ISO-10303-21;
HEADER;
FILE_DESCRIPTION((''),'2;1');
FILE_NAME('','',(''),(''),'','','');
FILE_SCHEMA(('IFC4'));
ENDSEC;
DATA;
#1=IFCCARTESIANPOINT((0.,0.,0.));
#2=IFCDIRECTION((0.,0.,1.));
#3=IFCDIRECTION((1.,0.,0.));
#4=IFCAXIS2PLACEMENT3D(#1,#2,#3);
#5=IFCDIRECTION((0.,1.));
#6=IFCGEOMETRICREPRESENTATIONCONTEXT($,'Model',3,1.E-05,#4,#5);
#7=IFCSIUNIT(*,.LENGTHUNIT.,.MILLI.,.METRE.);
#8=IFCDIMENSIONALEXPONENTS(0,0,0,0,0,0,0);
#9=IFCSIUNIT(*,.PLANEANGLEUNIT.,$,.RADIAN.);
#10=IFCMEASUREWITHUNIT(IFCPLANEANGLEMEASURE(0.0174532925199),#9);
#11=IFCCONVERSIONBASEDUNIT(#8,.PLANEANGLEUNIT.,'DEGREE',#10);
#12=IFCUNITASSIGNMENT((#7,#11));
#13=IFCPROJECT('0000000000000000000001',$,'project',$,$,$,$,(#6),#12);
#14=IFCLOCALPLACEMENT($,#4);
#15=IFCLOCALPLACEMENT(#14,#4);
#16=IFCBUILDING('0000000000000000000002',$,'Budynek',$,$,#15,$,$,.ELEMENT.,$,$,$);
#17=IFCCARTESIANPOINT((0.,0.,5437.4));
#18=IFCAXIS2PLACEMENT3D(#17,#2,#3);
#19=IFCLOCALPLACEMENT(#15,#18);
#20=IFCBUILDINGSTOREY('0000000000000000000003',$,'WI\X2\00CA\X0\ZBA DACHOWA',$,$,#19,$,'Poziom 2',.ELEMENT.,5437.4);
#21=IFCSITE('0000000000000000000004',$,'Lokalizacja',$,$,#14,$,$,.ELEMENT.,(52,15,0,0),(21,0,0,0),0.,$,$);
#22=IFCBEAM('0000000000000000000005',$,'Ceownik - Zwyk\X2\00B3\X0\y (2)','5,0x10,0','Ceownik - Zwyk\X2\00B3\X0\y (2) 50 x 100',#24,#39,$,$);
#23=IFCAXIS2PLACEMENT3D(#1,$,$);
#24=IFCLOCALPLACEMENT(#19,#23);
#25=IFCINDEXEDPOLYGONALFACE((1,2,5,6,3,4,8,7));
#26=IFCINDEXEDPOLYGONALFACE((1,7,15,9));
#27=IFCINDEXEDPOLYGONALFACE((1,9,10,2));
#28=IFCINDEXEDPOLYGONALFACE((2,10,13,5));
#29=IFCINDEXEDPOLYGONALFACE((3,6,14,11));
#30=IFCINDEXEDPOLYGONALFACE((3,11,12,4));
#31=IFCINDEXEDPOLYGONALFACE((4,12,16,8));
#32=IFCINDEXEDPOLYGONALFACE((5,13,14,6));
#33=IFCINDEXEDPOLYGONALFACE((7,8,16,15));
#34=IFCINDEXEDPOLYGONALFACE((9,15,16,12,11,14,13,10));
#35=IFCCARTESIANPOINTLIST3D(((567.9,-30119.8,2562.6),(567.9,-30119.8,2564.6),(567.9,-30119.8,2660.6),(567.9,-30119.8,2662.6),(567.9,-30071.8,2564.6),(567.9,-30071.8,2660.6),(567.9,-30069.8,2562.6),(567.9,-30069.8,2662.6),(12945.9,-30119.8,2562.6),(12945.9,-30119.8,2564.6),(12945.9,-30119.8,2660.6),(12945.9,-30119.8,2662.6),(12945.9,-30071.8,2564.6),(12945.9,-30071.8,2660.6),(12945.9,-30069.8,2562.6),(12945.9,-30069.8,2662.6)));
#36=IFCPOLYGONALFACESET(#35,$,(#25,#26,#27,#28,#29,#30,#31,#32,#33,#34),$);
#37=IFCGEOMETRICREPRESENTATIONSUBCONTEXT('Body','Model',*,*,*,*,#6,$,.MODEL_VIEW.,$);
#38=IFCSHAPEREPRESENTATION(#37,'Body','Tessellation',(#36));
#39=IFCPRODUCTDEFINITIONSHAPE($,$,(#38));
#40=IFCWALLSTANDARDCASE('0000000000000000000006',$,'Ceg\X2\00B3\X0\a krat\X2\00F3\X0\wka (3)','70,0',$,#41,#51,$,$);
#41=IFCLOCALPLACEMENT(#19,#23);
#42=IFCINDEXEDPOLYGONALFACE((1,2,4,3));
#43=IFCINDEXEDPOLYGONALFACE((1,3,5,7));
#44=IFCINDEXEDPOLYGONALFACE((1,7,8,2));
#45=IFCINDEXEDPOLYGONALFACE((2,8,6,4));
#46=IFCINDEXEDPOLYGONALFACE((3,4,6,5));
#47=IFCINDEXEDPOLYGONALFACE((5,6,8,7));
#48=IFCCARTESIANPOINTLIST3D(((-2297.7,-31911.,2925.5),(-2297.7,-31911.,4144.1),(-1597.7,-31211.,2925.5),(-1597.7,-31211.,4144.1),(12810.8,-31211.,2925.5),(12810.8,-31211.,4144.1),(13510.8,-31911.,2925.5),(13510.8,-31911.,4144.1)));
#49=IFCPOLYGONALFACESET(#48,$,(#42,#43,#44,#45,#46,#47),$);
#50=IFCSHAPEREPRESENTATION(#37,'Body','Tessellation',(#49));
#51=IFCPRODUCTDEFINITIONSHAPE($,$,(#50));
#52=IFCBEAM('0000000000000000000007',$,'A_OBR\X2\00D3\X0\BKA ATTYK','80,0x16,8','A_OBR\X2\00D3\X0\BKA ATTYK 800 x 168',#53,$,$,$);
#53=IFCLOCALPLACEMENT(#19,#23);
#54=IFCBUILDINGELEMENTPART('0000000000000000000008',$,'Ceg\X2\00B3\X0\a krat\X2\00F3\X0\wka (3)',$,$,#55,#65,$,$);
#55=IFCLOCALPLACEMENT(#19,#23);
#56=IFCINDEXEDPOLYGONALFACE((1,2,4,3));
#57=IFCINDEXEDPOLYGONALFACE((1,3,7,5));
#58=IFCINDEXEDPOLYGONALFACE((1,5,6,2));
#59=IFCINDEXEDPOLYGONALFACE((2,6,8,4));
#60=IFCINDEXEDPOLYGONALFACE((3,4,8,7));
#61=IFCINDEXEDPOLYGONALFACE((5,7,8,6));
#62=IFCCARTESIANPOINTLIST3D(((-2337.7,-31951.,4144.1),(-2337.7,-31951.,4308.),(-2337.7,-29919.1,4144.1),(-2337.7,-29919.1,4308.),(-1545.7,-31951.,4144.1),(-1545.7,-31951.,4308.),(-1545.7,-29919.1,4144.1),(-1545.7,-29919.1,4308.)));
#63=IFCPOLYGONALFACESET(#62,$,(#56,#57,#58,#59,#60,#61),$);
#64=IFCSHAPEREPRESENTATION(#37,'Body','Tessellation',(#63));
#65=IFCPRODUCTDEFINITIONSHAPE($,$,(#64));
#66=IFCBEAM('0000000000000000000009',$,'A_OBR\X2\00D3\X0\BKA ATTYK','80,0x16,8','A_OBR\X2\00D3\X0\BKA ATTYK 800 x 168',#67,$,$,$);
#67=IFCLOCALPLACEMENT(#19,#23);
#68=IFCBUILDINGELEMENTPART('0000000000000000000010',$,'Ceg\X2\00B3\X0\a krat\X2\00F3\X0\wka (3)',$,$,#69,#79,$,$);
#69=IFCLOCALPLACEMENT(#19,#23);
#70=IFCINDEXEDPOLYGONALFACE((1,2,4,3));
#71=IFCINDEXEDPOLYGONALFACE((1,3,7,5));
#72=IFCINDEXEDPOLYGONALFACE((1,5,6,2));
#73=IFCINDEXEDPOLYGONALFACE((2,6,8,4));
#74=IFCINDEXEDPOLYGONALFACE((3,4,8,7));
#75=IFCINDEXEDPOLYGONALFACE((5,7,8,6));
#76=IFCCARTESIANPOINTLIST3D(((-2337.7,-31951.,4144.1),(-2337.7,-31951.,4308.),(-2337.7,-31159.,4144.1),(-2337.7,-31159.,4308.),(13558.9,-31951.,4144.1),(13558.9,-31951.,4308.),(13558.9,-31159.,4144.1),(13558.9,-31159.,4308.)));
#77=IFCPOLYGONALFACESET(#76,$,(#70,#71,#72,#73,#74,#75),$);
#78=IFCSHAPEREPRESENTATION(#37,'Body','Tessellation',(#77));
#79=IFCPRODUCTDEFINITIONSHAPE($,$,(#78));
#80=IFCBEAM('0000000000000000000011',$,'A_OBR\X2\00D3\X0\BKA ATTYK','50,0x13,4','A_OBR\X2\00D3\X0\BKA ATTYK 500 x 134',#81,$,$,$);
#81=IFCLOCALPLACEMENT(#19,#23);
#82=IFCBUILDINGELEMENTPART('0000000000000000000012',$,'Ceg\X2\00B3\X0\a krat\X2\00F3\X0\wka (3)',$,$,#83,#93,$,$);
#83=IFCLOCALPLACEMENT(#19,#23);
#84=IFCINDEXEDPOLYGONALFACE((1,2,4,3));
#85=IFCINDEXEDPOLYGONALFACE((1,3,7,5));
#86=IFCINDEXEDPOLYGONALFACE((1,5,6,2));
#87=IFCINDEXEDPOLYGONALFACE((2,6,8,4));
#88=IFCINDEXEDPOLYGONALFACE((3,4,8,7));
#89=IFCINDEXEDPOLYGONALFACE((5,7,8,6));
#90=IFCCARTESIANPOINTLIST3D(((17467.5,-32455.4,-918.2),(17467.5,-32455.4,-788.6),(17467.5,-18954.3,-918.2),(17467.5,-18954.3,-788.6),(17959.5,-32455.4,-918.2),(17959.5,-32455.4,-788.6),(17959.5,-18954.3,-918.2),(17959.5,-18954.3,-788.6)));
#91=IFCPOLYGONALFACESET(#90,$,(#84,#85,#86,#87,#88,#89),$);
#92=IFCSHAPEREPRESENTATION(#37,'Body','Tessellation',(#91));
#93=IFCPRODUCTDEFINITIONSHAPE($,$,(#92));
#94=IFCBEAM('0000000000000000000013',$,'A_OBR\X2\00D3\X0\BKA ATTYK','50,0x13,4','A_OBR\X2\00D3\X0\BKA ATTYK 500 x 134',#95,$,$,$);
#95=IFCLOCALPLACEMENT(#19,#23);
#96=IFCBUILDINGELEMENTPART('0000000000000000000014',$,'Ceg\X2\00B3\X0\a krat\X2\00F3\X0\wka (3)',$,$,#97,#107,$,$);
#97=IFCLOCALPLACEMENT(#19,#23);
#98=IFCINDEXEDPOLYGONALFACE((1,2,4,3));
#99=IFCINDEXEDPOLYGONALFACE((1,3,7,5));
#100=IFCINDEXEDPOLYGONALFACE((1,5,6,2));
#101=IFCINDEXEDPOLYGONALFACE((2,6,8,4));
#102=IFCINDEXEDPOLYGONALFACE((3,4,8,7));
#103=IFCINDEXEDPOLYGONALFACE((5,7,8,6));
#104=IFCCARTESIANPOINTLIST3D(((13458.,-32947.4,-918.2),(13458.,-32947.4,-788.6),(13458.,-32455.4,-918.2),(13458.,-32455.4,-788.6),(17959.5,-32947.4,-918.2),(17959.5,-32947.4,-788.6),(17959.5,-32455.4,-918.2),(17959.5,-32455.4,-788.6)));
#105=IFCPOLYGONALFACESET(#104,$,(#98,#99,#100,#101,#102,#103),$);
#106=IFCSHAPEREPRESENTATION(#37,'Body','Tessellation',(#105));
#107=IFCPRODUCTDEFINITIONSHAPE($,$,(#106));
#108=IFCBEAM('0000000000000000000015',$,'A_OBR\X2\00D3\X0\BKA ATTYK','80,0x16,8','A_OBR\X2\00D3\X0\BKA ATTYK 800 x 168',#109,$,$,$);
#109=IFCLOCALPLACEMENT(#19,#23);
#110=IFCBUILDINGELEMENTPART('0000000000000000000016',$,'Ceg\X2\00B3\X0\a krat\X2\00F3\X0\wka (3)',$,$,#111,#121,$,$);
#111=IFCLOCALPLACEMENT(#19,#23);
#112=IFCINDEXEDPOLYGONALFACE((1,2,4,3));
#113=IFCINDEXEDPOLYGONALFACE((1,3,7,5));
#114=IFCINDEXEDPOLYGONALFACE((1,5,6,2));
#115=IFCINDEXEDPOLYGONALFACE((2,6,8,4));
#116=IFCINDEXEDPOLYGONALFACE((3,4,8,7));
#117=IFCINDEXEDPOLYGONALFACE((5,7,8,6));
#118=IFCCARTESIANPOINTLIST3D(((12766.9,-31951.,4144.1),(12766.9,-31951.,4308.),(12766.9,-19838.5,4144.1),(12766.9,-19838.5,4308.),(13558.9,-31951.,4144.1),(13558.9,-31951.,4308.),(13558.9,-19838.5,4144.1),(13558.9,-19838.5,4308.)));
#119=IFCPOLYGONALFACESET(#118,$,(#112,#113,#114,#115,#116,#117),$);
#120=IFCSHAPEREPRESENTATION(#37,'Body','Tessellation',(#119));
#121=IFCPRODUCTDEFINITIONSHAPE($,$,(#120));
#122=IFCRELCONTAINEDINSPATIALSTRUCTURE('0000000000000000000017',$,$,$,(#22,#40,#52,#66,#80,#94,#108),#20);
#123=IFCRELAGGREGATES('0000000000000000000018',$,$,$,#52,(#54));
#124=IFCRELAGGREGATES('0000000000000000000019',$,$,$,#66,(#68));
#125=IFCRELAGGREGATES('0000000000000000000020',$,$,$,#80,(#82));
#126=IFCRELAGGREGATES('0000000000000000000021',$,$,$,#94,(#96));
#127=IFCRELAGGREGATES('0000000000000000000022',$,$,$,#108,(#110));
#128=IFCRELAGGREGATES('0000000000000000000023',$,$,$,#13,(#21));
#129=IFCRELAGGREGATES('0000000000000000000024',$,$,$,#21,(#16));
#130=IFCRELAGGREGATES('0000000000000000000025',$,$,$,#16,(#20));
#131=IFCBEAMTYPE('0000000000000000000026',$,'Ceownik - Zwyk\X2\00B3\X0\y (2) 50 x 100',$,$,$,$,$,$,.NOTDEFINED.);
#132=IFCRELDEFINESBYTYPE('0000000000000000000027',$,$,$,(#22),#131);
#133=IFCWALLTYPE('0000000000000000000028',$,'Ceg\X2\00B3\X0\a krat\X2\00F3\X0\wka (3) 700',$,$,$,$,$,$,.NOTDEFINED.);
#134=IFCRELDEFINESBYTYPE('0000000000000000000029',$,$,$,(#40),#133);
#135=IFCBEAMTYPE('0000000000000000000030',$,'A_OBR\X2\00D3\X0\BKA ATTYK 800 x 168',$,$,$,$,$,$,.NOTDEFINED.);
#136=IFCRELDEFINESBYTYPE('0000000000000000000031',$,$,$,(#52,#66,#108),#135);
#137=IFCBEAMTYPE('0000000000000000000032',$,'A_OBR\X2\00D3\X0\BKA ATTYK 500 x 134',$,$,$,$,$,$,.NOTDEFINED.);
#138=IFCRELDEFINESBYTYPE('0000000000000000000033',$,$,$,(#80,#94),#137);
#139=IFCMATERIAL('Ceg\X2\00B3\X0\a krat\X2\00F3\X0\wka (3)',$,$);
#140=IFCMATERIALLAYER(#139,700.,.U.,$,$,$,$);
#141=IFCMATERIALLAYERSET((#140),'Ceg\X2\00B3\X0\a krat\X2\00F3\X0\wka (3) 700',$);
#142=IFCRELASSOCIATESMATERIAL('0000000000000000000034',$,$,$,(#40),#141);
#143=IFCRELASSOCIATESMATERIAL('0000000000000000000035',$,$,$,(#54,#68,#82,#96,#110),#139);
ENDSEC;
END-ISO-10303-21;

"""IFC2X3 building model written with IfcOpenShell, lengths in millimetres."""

from ifc_helpers import new_model, entity, si_unit, converted_unit, direction, frame, origin_with_axes, place, context, subcontext, project, spatial, polyline, outline, extrude, material, layer, layer_set, layer_usage, type_object, element, aggregate, save


model = new_model("IFC2X3")

# Units and contexts
model_context = context("Model", 3, precision=1e-05, world=origin_with_axes(), true_north=direction((0.0, 1.0)))
body_context = subcontext(model_context, "Body", "Model", "MODEL_VIEW")
ifc_project = project(units=[si_unit("LENGTHUNIT", "METRE", prefix="MILLI"), converted_unit("PLANEANGLEUNIT", "DEGREE", entity("IfcPlaneAngleMeasure", 0.0174532925199), si_unit("PLANEANGLEUNIT", "RADIAN"), dimensions=[0, 0, 0, 0, 0, 0, 0])], contexts=[model_context])

# Site, building, storey
site_placement = place(None, origin_with_axes())
site = spatial("IfcSite", under=ifc_project, at=site_placement, Name="Lokalizacja", CompositionType="ELEMENT", RefLatitude=(52, 15, 0, 0), RefLongitude=(21, 0, 0, 0), RefElevation=0.0)
building_placement = place(site_placement, origin_with_axes())
building = spatial("IfcBuilding", under=site, at=building_placement, Name="Budynek", CompositionType="ELEMENT")
storey_placement = place(building_placement, frame((0.0, 0.0, 5437.4), z_axis=(0.0, 0.0, 1.0), x_axis=(1.0, 0.0, 0.0)))
storey = spatial("IfcBuildingStorey", under=building, at=storey_placement, Name="WIÊZBA DACHOWA", LongName="Poziom 2", CompositionType="ELEMENT", Elevation=5437.4)

# Beam
beam_type_1 = type_object("IfcBeamType", Name="Ceownik - Zwyk³y (2) 50 x 100", PredefinedType="NOTDEFINED")
beam_1_placement = place(storey_placement, frame((567.9, -30094.8, 2662.6), z_axis=(0.0, 0.0, 1.0), x_axis=(0.0, -1.0, 0.0)))
element("IfcBeam", 1, at=beam_1_placement, inside=storey, type_object=beam_type_1, Name="Ceownik - Zwyk³y (2)", Description="5,0x10,0", ObjectType="Ceownik - Zwyk³y (2) 50 x 100", context=body_context, shape_type="SweptSolid", body=[
    extrude(outline(polyline([(25.0, -100.0), (25.0, -98.0), (-23.0, -98.0), (-23.0, -2.0), (25.0, -2.0), (25.0, 0.0), (-25.0, 0.0), (-25.0, -100.0), (25.0, -100.0)])), frame((0.0, 12378.0, 0.0), z_axis=(0.0, -1.0, 0.0), x_axis=(1.0, 0.0, 0.0)), (0.0, 0.0, 1.0), 12378.0),
])

# Wall
ifc_material_1 = material(Name="Ceg³a kratówka (3)")
ifc_layer = layer(ifc_material_1, 700.0, ventilated="UNKNOWN")
ifc_layer_set = layer_set([ifc_layer], Name="Ceg³a kratówka (3) 700")
ifc_layer_usage = layer_usage(ifc_layer_set, "AXIS2", "NEGATIVE", 0.0)
wall_type = type_object("IfcWallType", Name="Ceg³a kratówka (3) 700", PredefinedType="NOTDEFINED")
wall_placement = place(storey_placement, frame((-1597.7, -31211.0, 2925.5), z_axis=(0.0, 0.0, 1.0), x_axis=(1.0, 0.0, 0.0)))
element("IfcWallStandardCase", 2, at=wall_placement, inside=storey, type_object=wall_type, material=ifc_layer_usage, Name="Ceg³a kratówka (3)", Description="70,0", context=body_context, shape_type="SweptSolid", body=[
    extrude(outline(polyline([(-700.0, -700.0), (15108.5, -700.0), (14408.5, 0.0), (0.0, 0.0), (-700.0, -700.0)])), origin_with_axes(), (0.0, 0.0, 1.0), 1218.6),
])

# Beams, building element parts
beam_type_2 = type_object("IfcBeamType", Name="A_OBRÓBKA ATTYK 800 x 168", PredefinedType="NOTDEFINED")
beam_2_placement = place(storey_placement, frame((-2337.7, -29919.1, 4144.1), z_axis=(0.0, 0.0, 1.0), x_axis=(-1.0, 0.0, 0.0)))
beam_2 = element("IfcBeam", 3, at=beam_2_placement, inside=storey, type_object=beam_type_2, Name="A_OBRÓBKA ATTYK", Description="80,0x16,8", ObjectType="A_OBRÓBKA ATTYK 800 x 168")
building_element_part_1_placement = place(beam_2_placement, origin_with_axes())
building_element_part_1 = element("IfcBuildingElementPart", 4, at=building_element_part_1_placement, material=ifc_material_1, Name="Ceg³a kratówka (3)", context=body_context, shape_type="SweptSolid", body=[
    extrude(outline(polyline([(0.0, 0.0), (0.0, 163.9), (-792.0, 163.9), (-792.0, 0.0), (0.0, 0.0)])), frame((0.0, 2031.9, 0.0), z_axis=(0.0, -1.0, 0.0), x_axis=(1.0, 0.0, 0.0)), (0.0, 0.0, 1.0), 2031.9),
])
aggregate(beam_2, [building_element_part_1])
beam_3_placement = place(storey_placement, frame((-2337.7, -31951.0, 4144.1), z_axis=(0.0, 0.0, 1.0), x_axis=(0.0, -1.0, 0.0)))
beam_3 = element("IfcBeam", 5, at=beam_3_placement, inside=storey, type_object=beam_type_2, Name="A_OBRÓBKA ATTYK", Description="80,0x16,8", ObjectType="A_OBRÓBKA ATTYK 800 x 168")
building_element_part_2_placement = place(beam_3_placement, origin_with_axes())
building_element_part_2 = element("IfcBuildingElementPart", 6, at=building_element_part_2_placement, material=ifc_material_1, Name="Ceg³a kratówka (3)", context=body_context, shape_type="SweptSolid", body=[
    extrude(outline(polyline([(0.0, 0.0), (0.0, 163.9), (-792.0, 163.9), (-792.0, 0.0), (0.0, 0.0)])), frame((0.0, 15896.6, 0.0), z_axis=(0.0, -1.0, 0.0), x_axis=(1.0, 0.0, 0.0)), (0.0, 0.0, 1.0), 15896.6),
])
aggregate(beam_3, [building_element_part_2])
beam_type_3 = type_object("IfcBeamType", Name="A_OBRÓBKA ATTYK 500 x 134", PredefinedType="NOTDEFINED")
beam_4_placement = place(storey_placement, frame((17959.5, -32455.4, -918.2), z_axis=(0.0, 0.0, 1.0), x_axis=(1.0, 0.0, 0.0)))
beam_4 = element("IfcBeam", 7, at=beam_4_placement, inside=storey, type_object=beam_type_3, Name="A_OBRÓBKA ATTYK", Description="50,0x13,4", ObjectType="A_OBRÓBKA ATTYK 500 x 134")
building_element_part_3_placement = place(beam_4_placement, origin_with_axes())
building_element_part_3 = element("IfcBuildingElementPart", 8, at=building_element_part_3_placement, material=ifc_material_1, Name="Ceg³a kratówka (3)", context=body_context, shape_type="SweptSolid", body=[
    extrude(outline(polyline([(0.0, 0.0), (0.0, 129.6), (-492.0, 129.6), (-492.0, 0.0), (0.0, 0.0)])), frame((0.0, 13501.1, 0.0), z_axis=(0.0, -1.0, 0.0), x_axis=(1.0, 0.0, 0.0)), (0.0, 0.0, 1.0), 13501.1),
])
aggregate(beam_4, [building_element_part_3])
beam_5_placement = place(storey_placement, frame((17959.5, -32455.4, -918.2), z_axis=(0.0, 0.0, 1.0), x_axis=(0.0, 1.0, 0.0)))
beam_5 = element("IfcBeam", 9, at=beam_5_placement, inside=storey, type_object=beam_type_3, Name="A_OBRÓBKA ATTYK", Description="50,0x13,4", ObjectType="A_OBRÓBKA ATTYK 500 x 134")
building_element_part_4_placement = place(beam_5_placement, origin_with_axes())
building_element_part_4 = element("IfcBuildingElementPart", 10, at=building_element_part_4_placement, material=ifc_material_1, Name="Ceg³a kratówka (3)", context=body_context, shape_type="SweptSolid", body=[
    extrude(outline(polyline([(0.0, 0.0), (0.0, 129.6), (-492.0, 129.6), (-492.0, 0.0), (0.0, 0.0)])), frame((0.0, 4501.6, 0.0), z_axis=(0.0, -1.0, 0.0), x_axis=(1.0, 0.0, 0.0)), (0.0, 0.0, 1.0), 4501.6),
])
aggregate(beam_5, [building_element_part_4])
beam_6_placement = place(storey_placement, frame((13558.9, -31951.0, 4144.1), z_axis=(0.0, 0.0, 1.0), x_axis=(1.0, 0.0, 0.0)))
beam_6 = element("IfcBeam", 11, at=beam_6_placement, inside=storey, type_object=beam_type_2, Name="A_OBRÓBKA ATTYK", Description="80,0x16,8", ObjectType="A_OBRÓBKA ATTYK 800 x 168")
building_element_part_5_placement = place(beam_6_placement, origin_with_axes())
building_element_part_5 = element("IfcBuildingElementPart", 12, at=building_element_part_5_placement, material=ifc_material_1, Name="Ceg³a kratówka (3)", context=body_context, shape_type="SweptSolid", body=[
    extrude(outline(polyline([(0.0, 0.0), (0.0, 163.9), (-792.0, 163.9), (-792.0, 0.0), (0.0, 0.0)])), frame((0.0, 12112.5, 0.0), z_axis=(0.0, -1.0, 0.0), x_axis=(1.0, 0.0, 0.0)), (0.0, 0.0, 1.0), 12112.5),
])
aggregate(beam_6, [building_element_part_5])

save(model, "model.ifc")
